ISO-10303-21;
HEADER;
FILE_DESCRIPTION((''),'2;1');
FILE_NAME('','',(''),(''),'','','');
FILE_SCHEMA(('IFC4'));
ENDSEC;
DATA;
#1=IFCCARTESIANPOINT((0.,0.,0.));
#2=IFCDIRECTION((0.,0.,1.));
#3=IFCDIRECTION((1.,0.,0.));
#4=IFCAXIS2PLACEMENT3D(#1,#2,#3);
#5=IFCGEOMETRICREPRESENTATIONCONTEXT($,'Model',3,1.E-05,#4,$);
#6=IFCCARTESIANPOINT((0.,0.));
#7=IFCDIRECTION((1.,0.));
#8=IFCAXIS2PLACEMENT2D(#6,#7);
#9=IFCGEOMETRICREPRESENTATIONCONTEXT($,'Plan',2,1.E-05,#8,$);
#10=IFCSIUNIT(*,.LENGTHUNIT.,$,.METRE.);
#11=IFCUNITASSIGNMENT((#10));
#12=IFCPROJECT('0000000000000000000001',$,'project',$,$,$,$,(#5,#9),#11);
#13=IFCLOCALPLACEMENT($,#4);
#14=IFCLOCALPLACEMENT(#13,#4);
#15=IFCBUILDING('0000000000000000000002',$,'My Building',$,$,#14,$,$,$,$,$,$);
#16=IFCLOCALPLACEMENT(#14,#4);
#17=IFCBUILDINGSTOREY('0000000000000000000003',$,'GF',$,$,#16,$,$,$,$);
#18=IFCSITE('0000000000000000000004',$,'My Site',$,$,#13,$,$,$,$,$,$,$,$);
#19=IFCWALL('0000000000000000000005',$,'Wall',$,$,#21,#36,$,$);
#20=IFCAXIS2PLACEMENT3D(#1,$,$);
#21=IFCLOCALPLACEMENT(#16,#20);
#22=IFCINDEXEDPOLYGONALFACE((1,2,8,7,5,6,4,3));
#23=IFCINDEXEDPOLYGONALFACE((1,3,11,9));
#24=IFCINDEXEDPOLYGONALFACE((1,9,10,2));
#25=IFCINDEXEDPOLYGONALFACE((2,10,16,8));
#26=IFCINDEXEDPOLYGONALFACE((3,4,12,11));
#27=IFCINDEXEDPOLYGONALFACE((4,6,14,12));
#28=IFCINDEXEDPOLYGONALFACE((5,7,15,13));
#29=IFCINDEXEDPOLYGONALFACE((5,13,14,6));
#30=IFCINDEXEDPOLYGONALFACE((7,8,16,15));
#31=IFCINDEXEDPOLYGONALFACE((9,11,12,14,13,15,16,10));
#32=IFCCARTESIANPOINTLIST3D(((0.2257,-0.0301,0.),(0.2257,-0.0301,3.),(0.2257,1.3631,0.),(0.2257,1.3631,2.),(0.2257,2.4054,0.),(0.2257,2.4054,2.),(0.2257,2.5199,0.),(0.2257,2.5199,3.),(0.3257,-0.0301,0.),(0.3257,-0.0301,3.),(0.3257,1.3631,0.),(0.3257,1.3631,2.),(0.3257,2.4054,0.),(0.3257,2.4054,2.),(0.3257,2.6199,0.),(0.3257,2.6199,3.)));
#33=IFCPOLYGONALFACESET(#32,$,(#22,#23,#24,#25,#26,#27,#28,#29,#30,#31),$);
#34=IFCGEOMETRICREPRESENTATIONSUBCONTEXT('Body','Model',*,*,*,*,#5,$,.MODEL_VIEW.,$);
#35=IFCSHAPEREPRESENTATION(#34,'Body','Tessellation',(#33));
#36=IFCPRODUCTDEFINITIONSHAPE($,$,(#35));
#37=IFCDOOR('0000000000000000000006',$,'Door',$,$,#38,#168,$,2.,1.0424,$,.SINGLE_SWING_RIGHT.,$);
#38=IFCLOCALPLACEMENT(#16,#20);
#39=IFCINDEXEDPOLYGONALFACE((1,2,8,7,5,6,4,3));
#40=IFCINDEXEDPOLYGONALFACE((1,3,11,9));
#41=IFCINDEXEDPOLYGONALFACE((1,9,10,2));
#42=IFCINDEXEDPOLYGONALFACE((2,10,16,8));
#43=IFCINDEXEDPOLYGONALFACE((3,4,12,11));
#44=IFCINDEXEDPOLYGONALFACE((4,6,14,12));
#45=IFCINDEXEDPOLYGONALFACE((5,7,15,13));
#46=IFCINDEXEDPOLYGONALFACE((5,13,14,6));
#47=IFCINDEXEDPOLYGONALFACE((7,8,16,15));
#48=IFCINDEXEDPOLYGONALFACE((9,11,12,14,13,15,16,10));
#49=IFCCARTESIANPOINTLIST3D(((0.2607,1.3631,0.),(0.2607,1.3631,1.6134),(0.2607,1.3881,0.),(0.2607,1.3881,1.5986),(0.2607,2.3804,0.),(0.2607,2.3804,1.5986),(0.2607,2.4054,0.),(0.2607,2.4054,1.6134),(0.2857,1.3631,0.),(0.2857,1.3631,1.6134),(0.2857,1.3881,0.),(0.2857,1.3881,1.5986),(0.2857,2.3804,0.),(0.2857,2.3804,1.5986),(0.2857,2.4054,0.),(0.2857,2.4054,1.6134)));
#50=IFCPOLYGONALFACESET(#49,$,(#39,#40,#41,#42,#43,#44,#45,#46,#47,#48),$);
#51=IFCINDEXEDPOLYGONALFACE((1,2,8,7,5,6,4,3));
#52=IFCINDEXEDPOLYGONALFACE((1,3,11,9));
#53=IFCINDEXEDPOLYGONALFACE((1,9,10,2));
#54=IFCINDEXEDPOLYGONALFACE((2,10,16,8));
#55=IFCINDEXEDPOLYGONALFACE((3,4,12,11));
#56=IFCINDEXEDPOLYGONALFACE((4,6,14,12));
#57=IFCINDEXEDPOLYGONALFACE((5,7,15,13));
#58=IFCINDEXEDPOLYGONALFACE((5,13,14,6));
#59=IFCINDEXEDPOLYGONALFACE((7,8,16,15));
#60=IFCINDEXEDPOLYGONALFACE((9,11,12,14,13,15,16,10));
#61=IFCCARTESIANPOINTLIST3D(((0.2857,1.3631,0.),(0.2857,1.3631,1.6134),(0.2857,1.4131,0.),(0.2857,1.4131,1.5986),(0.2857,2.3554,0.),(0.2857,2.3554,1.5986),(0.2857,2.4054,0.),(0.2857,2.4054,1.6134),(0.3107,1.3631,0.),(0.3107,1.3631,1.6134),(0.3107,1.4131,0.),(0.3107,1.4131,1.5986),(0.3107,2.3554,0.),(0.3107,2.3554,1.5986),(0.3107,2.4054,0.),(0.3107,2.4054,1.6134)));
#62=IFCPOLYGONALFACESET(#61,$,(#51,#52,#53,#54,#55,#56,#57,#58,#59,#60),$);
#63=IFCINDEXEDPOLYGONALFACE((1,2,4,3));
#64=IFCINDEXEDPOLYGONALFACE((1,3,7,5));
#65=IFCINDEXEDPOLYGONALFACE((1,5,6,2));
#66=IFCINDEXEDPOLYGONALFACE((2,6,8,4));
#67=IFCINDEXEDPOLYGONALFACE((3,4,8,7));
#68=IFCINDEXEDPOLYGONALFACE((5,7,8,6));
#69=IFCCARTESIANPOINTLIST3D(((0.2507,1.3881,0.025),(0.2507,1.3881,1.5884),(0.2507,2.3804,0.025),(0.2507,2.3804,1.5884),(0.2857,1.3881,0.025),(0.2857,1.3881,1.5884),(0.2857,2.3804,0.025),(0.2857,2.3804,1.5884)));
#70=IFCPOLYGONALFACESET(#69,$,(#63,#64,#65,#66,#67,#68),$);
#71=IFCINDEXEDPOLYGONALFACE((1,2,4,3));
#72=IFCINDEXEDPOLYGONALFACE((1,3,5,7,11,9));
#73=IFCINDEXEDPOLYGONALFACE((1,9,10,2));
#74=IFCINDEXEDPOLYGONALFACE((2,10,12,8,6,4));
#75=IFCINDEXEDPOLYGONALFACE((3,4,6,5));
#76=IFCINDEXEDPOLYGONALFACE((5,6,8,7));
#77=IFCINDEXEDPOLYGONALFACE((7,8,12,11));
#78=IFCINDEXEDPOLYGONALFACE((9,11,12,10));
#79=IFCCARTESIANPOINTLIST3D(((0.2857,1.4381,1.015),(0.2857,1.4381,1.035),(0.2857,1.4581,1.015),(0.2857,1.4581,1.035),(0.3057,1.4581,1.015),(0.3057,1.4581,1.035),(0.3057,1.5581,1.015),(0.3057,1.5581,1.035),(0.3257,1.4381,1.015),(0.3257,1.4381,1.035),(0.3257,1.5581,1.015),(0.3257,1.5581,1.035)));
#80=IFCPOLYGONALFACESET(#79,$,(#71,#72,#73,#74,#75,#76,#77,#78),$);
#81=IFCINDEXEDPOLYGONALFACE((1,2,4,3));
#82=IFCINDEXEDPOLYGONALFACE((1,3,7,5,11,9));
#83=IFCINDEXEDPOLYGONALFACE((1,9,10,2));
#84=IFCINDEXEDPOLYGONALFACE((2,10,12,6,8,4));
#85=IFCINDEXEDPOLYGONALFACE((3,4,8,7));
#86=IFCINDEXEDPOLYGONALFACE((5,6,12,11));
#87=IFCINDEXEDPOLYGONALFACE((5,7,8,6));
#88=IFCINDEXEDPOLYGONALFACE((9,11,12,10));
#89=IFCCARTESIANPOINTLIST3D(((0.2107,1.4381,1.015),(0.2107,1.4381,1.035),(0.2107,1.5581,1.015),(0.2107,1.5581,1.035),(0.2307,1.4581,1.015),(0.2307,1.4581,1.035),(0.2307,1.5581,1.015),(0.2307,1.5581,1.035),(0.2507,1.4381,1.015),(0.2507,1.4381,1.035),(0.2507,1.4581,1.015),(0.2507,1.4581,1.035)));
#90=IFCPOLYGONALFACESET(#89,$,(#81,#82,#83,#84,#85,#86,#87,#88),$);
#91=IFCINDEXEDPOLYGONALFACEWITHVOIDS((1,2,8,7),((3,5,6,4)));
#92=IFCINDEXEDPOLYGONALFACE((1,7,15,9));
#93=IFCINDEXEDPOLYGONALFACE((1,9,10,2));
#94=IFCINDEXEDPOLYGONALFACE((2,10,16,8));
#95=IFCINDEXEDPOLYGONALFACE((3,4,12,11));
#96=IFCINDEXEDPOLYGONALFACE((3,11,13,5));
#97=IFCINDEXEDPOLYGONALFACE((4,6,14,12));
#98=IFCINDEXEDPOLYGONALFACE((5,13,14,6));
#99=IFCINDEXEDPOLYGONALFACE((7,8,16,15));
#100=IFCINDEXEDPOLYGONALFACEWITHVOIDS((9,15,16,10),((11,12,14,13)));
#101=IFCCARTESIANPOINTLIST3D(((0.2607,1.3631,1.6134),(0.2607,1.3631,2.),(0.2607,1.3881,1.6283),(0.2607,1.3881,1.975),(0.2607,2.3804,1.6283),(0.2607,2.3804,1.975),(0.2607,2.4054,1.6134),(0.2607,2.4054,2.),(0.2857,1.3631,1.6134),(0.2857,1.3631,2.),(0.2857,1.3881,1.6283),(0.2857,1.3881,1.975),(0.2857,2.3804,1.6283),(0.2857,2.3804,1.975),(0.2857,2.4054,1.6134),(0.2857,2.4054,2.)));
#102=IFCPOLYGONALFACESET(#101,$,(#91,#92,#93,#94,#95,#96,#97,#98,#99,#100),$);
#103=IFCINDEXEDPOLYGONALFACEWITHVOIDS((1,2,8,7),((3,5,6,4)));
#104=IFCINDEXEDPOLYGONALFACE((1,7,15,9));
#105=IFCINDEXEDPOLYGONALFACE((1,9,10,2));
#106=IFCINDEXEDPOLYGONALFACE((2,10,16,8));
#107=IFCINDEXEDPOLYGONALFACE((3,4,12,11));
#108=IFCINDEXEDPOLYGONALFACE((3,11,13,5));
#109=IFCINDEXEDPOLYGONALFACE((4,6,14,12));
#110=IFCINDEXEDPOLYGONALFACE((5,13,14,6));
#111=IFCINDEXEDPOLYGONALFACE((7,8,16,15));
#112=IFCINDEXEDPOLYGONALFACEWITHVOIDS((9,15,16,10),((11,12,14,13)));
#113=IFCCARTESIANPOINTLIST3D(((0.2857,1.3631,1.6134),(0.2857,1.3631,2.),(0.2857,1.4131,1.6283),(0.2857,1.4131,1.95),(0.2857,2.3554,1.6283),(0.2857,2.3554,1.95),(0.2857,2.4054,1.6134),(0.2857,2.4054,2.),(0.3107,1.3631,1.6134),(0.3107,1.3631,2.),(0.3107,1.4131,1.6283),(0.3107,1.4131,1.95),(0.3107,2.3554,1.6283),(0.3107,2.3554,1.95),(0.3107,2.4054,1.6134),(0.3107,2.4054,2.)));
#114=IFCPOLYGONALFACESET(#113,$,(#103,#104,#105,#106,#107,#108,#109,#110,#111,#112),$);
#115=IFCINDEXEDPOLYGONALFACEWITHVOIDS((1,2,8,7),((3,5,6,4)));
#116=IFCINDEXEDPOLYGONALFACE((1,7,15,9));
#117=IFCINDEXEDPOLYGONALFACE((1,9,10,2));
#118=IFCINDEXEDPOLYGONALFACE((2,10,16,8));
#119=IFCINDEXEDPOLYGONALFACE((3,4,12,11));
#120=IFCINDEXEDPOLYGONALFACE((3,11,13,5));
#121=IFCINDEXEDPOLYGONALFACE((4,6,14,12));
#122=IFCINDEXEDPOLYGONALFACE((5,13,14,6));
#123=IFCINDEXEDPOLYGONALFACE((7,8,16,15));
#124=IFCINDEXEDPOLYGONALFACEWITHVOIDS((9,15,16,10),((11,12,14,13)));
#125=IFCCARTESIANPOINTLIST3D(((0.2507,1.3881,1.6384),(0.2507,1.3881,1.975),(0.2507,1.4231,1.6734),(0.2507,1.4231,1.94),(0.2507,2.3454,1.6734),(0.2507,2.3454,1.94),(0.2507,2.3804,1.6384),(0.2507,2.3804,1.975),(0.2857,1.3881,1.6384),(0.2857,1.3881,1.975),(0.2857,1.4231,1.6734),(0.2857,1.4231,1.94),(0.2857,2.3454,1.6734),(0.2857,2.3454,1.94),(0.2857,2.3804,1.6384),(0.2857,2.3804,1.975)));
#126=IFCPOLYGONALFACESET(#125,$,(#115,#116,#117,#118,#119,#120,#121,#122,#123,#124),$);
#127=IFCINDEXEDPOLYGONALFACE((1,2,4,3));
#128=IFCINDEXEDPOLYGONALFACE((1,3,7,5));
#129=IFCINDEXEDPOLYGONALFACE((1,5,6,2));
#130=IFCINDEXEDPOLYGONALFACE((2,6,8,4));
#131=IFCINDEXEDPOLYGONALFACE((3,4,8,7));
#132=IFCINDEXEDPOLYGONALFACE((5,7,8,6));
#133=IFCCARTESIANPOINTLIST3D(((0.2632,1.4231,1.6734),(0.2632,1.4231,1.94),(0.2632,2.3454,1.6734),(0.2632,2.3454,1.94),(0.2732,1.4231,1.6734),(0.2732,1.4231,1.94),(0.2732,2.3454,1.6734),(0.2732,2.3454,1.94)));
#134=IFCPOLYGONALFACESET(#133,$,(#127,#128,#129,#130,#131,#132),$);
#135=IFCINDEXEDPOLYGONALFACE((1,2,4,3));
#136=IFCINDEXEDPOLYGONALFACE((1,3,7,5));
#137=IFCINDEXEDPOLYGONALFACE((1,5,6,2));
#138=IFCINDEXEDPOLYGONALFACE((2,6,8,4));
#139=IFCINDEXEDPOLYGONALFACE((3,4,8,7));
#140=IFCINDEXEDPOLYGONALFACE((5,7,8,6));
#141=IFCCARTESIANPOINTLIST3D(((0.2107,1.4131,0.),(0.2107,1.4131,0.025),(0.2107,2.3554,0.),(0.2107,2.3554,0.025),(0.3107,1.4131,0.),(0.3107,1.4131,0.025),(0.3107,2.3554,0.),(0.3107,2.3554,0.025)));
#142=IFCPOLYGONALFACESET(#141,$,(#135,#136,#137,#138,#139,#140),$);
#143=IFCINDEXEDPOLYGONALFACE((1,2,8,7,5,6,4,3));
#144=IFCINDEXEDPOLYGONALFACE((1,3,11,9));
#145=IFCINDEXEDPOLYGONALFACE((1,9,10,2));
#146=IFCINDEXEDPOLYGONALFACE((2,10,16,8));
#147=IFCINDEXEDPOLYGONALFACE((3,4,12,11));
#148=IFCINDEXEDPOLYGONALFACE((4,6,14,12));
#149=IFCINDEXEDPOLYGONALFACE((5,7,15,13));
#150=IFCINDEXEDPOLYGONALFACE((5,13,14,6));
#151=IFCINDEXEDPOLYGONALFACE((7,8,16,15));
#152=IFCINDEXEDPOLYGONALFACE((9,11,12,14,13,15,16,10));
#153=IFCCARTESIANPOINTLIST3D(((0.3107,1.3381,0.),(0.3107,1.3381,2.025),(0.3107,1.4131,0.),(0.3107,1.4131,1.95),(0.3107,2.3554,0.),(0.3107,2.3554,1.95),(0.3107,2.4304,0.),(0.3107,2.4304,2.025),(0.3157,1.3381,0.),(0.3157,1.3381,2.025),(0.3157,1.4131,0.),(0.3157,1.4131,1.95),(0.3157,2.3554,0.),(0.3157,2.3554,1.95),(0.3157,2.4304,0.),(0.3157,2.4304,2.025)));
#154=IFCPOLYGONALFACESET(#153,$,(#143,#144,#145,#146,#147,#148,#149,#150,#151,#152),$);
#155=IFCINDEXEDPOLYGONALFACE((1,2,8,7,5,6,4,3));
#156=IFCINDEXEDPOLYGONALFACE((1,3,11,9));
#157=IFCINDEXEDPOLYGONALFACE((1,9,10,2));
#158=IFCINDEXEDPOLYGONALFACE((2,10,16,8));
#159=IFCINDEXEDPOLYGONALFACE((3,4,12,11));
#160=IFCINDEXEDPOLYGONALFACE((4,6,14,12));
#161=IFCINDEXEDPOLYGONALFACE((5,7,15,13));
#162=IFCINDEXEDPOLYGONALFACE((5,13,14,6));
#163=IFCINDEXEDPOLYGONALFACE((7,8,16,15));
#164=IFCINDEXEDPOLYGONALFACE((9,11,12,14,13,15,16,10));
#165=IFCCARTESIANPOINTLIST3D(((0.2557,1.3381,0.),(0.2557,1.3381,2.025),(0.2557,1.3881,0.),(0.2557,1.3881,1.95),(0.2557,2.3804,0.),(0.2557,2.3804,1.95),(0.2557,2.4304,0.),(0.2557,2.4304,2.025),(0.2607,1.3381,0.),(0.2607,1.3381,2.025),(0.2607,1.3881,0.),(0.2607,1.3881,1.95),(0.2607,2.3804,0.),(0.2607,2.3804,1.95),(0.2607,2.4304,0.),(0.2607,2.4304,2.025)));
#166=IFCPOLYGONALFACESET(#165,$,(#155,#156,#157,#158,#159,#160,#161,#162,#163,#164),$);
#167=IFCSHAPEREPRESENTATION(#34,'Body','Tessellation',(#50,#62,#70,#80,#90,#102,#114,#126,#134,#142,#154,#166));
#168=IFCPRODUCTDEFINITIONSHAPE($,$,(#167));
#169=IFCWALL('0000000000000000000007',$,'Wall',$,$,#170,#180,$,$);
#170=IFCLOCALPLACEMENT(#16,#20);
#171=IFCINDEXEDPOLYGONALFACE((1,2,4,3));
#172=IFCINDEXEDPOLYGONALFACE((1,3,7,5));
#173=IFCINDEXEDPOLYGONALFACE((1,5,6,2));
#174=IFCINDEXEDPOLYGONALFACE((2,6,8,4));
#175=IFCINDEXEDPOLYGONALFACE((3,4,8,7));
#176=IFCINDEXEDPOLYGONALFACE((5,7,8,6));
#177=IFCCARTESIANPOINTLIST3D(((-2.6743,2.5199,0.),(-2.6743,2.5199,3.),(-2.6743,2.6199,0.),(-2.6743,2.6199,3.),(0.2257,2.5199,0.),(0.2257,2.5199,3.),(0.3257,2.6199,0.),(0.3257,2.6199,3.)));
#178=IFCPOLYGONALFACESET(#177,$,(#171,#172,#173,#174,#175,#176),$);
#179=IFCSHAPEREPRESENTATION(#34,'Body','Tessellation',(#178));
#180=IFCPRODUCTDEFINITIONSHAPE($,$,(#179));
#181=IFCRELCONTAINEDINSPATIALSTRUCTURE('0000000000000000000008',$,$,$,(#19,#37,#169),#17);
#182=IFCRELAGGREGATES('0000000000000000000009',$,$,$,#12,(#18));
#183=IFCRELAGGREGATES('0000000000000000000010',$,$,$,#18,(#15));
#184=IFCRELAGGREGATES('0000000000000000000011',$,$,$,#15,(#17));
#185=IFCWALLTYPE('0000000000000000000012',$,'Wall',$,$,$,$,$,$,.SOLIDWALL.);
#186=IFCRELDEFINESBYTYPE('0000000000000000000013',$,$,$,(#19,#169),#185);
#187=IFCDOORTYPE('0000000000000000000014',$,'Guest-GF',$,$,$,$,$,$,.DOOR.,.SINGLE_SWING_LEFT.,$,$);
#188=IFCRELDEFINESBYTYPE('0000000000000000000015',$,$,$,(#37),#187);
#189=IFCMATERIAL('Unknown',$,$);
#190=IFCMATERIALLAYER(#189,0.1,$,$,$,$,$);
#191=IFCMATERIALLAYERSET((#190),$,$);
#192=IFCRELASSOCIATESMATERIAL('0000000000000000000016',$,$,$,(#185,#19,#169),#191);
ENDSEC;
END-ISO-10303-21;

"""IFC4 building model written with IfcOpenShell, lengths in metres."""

from ifc_helpers import new_model, entity, si_unit, frame, origin_with_axes, origin_2d_with_axis, place, context, subcontext, project, spatial, line, indexed_curve, outline, extrude, shape, source, transform, mapped, material, layer, layer_set, layer_usage, type_object, type_shapes, element, fill, save


model = new_model("IFC4")

# Units and contexts
model_context = context("Model", 3, precision=1e-05, world=origin_with_axes())
plan_context = context("Plan", 2, precision=1e-05, world=origin_2d_with_axis())
body_context_1 = subcontext(model_context, "Body", "Model", "MODEL_VIEW")
body_context_2 = subcontext(plan_context, "Body", "Plan", "PLAN_VIEW")
ifc_project = project(units=[si_unit("LENGTHUNIT", "METRE")], contexts=[model_context, plan_context])

# Site, building, storey
site_placement = place(None, origin_with_axes())
site = spatial("IfcSite", under=ifc_project, at=site_placement, Name="My Site")
building_placement = place(site_placement, origin_with_axes())
building = spatial("IfcBuilding", under=site, at=building_placement, Name="My Building")
storey_placement = place(building_placement, origin_with_axes())
storey = spatial("IfcBuildingStorey", under=building, at=storey_placement, Name="GF")

# Shared definitions
ifc_material = material(Name="Unknown")

# Shared definitions
ifc_layer_1 = layer(ifc_material, 0.1)
ifc_layer_set_1 = layer_set([ifc_layer_1])
wall_type = type_object("IfcWallType", Name="Wall", PredefinedType="SOLIDWALL", material=ifc_layer_set_1)

# Wall, opening, door
ifc_layer_usage_1 = layer_usage(ifc_layer_set_1, "AXIS2", "POSITIVE", 0.0)
wall_1_placement = place(storey_placement, frame((0.3257, -0.0301, 0.0), z_axis=(0.0, 0.0, 1.0), x_axis=(0.0, 1.0, 0.0)))
wall_1 = element("IfcWall", 1, at=wall_1_placement, inside=storey, type_object=wall_type, material=ifc_layer_usage_1, Name="Wall", context=body_context_1, shape_type="SweptSolid", body=[
    extrude(outline(indexed_curve([(0.0, 0.0), (0.0, 0.1), (2.55, 0.1), (2.65, 0.0)], segments=[line(1, 2, 3, 4, 1)])), origin_with_axes(), (0.0, 0.0, 1.0), 3.0),
])
shared_shape_1 = source(origin_with_axes(), body_context_1, "Body", "SweptSolid", [
    extrude(outline(indexed_curve([(0.0, 0.0), (1.0424, 0.0), (1.0424, 2.0), (0.0, 2.0)], segments=[line(1, 2, 3, 4, 1)])), frame((0.0, -0.6, 0.0), z_axis=(0.0, -1.0, 0.0), x_axis=(1.0, 0.0, 0.0)), (0.0, 0.0, -1.0), 1.2),
])
opening_1_placement = place(wall_1_placement, frame((1.3932, 0.015, 0.0), z_axis=(0.0, 0.0, 1.0), x_axis=(1.0, 0.0, 0.0)))
opening_1 = element("IfcOpeningElement", 2, at=opening_1_placement, cuts=wall_1, PredefinedType="OPENING", context=body_context_1, shape_type="MappedRepresentation", body=[
    mapped(shared_shape_1, transform((0.0, 0.0, 0.0), x_axis=(1.0, 0.0, 0.0), y_axis=(0.0, 1.0, 0.0), z_axis=(0.0, 0.0, 1.0), scale=1.0)),
])
door_type_1 = type_object("IfcDoorType", Name="Guest-GF", OperationType="SINGLE_SWING_LEFT", PredefinedType="DOOR")
shared_shape_2 = source(origin_with_axes(), body_context_1, "Body", "SweptSolid", [
    extrude(outline(indexed_curve([(0.0, 0.0), (0.0, 1.6134), (1.0424, 1.6134), (1.0424, 0.0), (1.0174, 0.0), (1.0174, 1.5986), (0.025, 1.5986), (0.025, 0.0)], segments=[line(1, 2, 3, 4, 5, 6, 7, 8, 1)])), frame((0.0, 0.025, 0.0), z_axis=(0.0, -1.0, 0.0), x_axis=(1.0, 0.0, 0.0)), (0.0, 0.0, -1.0), 0.025),
    extrude(outline(indexed_curve([(0.0, 0.0), (0.0, 1.6134), (1.0424, 1.6134), (1.0424, 0.0), (0.9924, 0.0), (0.9924, 1.5986), (0.05, 1.5986), (0.05, 0.0)], segments=[line(1, 2, 3, 4, 5, 6, 7, 8, 1)])), frame((0.0, 0.0, 0.0), z_axis=(0.0, -1.0, 0.0), x_axis=(1.0, 0.0, 0.0)), (0.0, 0.0, -1.0), 0.025),
    extrude(outline(indexed_curve([(0.0, 0.0), (0.9924, 0.0), (0.9924, 0.035), (0.0, 0.035)], segments=[line(1, 2, 3, 4, 1)])), frame((0.025, 0.025, 0.025), z_axis=(0.0, 0.0, 1.0), x_axis=(1.0, 0.0, 0.0)), (0.0, 0.0, 1.0), 1.5634),
    extrude(outline(indexed_curve([(0.0, 0.0), (0.0, -0.04), (0.12, -0.04), (0.12, -0.02), (0.02, -0.02), (0.02, 0.0)], segments=[line(1, 2, 3, 4, 5, 6, 1)])), frame((0.075, 0.025, 1.015), z_axis=(0.0, 0.0, 1.0), x_axis=(1.0, 0.0, 0.0)), (0.0, 0.0, 1.0), 0.02),
    extrude(outline(indexed_curve([(0.0, 0.0), (0.0, 0.04), (0.12, 0.04), (0.12, 0.02), (0.02, 0.02), (0.02, 0.0)], segments=[line(1, 2, 3, 4, 5, 6, 1)])), frame((0.075, 0.06, 1.015), z_axis=(0.0, 0.0, 1.0), x_axis=(1.0, 0.0, 0.0)), (0.0, 0.0, 1.0), 0.02),
    extrude(outline(indexed_curve([(0.0, 0.0), (1.0424, 0.0), (1.0424, 0.3866), (0.0, 0.3866)], segments=[line(1, 2, 3, 4, 1)]), holes=[indexed_curve([(0.025, 0.0148), (1.0174, 0.0148), (1.0174, 0.3616), (0.025, 0.3616)], segments=[line(1, 2, 3, 4, 1)])]), frame((0.0, 0.025, 1.6134), z_axis=(0.0, -1.0, 0.0), x_axis=(1.0, 0.0, 0.0)), (0.0, 0.0, -1.0), 0.025),
    extrude(outline(indexed_curve([(0.0, 0.0), (1.0424, 0.0), (1.0424, 0.3866), (0.0, 0.3866)], segments=[line(1, 2, 3, 4, 1)]), holes=[indexed_curve([(0.05, 0.0148), (0.9924, 0.0148), (0.9924, 0.3366), (0.05, 0.3366)], segments=[line(1, 2, 3, 4, 1)])]), frame((0.0, 0.0, 1.6134), z_axis=(0.0, -1.0, 0.0), x_axis=(1.0, 0.0, 0.0)), (0.0, 0.0, -1.0), 0.025),
    extrude(outline(indexed_curve([(0.0, 0.0), (0.9924, 0.0), (0.9924, 0.3366), (0.0, 0.3366)], segments=[line(1, 2, 3, 4, 1)]), holes=[indexed_curve([(0.035, 0.035), (0.9574, 0.035), (0.9574, 0.3016), (0.035, 0.3016)], segments=[line(1, 2, 3, 4, 1)])]), frame((0.025, 0.025, 1.6384), z_axis=(0.0, -1.0, 0.0), x_axis=(1.0, 0.0, 0.0)), (0.0, 0.0, -1.0), 0.035),
    extrude(outline(indexed_curve([(0.035, 0.035), (0.9574, 0.035), (0.9574, 0.3016), (0.035, 0.3016)], segments=[line(1, 2, 3, 4, 1)])), frame((0.025, 0.0375, 1.6384), z_axis=(0.0, -1.0, 0.0), x_axis=(1.0, 0.0, 0.0)), (0.0, 0.0, -1.0), 0.01),
    extrude(outline(indexed_curve([(0.0, 0.0), (0.9424, 0.0), (0.9424, 0.1), (0.0, 0.1)], segments=[line(1, 2, 3, 4, 1)])), frame((0.05, 0.0, 0.0), z_axis=(0.0, 0.0, 1.0), x_axis=(1.0, 0.0, 0.0)), (0.0, 0.0, 1.0), 0.025),
    extrude(outline(indexed_curve([(0.0, 0.0), (0.0, 2.025), (1.0924, 2.025), (1.0924, 0.0), (1.0174, 0.0), (1.0174, 1.95), (0.075, 1.95), (0.075, 0.0)], segments=[line(1, 2, 3, 4, 5, 6, 7, 8, 1)])), frame((-0.025, -0.005, 0.0), z_axis=(0.0, -1.0, 0.0), x_axis=(1.0, 0.0, 0.0)), (0.0, 0.0, -1.0), 0.005),
    extrude(outline(indexed_curve([(0.0, 0.0), (0.0, 2.025), (1.0924, 2.025), (1.0924, 0.0), (1.0424, 0.0), (1.0424, 1.95), (0.05, 1.95), (0.05, 0.0)], segments=[line(1, 2, 3, 4, 5, 6, 7, 8, 1)])), frame((-0.025, 0.05, 0.0), z_axis=(0.0, -1.0, 0.0), x_axis=(1.0, 0.0, 0.0)), (0.0, 0.0, -1.0), 0.005),
])
shared_shape_3 = source(origin_with_axes(), body_context_2, "Body", "Curve2D", [
    entity("IfcIndexedPolyCurve", entity("IfcCartesianPointList2D", [[0.0, 0.0], [0.0, 0.05], [0.025, 0.05], [0.025, 0.025], [0.05, 0.025], [0.05, 0.0]]), [entity("IfcLineIndex", [1, 2, 3, 4, 5, 6, 1])]),
    entity("IfcIndexedPolyCurve", entity("IfcCartesianPointList2D", [[1.0424, 0.0], [1.0424, 0.05], [1.0174, 0.05], [1.0174, 0.025], [0.9924, 0.025], [0.9924, 0.0]]), [entity("IfcLineIndex", [1, 2, 3, 4, 5, 6, 1])]),
    entity("IfcTrimmedCurve", entity("IfcEllipse", entity("IfcAxis2Placement2D", entity("IfcCartesianPoint", [0.9824, 0.05]), entity("IfcDirection", [1.0, 0.0])), 0.9574, 0.9924), [entity("IfcCartesianPoint", [0.9824, 1.0424])], [entity("IfcCartesianPoint", [0.025, 0.05])], True, "CARTESIAN"),
    entity("IfcIndexedPolyCurve", entity("IfcCartesianPointList2D", [[1.0174, 0.05], [0.9824, 0.05], [0.9824, 1.0424], [1.0174, 1.0424]]), [entity("IfcLineIndex", [1, 2, 3, 4, 1])]),
])
type_shapes(door_type_1, [shared_shape_2, shared_shape_3])
door_1_placement = place(opening_1_placement, frame((0.0, 0.0, 0.0), z_axis=(0.0, 0.0, 1.0), x_axis=(1.0, 0.0, 0.0)))
door_1 = element("IfcDoor", 3, at=door_1_placement, inside=storey, type_object=door_type_1, Name="Door", OperationType="SINGLE_SWING_RIGHT", OverallHeight=2.0, OverallWidth=1.0424, shapes=[
    shape(body_context_1, "Body", "MappedRepresentation", [mapped(shared_shape_2, transform((0.0, 0.0, 0.0), x_axis=(1.0, 0.0, 0.0), y_axis=(0.0, 1.0, 0.0), z_axis=(0.0, 0.0, 1.0), scale=1.0))]),
    shape(body_context_2, "Body", "MappedRepresentation", [mapped(shared_shape_3, transform((0.0, 0.0, 0.0), x_axis=(1.0, 0.0, 0.0), y_axis=(0.0, 1.0, 0.0), z_axis=(0.0, 0.0, 1.0), scale=1.0))]),
])
fill(opening_1, door_1)

# Wall
ifc_layer_usage_2 = layer_usage(ifc_layer_set_1, "AXIS2", "POSITIVE", 0.0)
wall_2_placement = place(storey_placement, frame((0.3257, 2.6199, 0.0), z_axis=(0.0, 0.0, 1.0), x_axis=(-1.0, 0.0, 0.0)))
element("IfcWall", 4, at=wall_2_placement, inside=storey, type_object=wall_type, material=ifc_layer_usage_2, Name="Wall", context=body_context_1, shape_type="SweptSolid", body=[
    extrude(outline(indexed_curve([(0.0, 0.0), (0.1, 0.1), (3.0, 0.1), (3.0, 0.0)], segments=[line(1, 2, 3, 4, 1)])), origin_with_axes(), (0.0, 0.0, 1.0), 3.0),
])

save(model, "model.ifc")
